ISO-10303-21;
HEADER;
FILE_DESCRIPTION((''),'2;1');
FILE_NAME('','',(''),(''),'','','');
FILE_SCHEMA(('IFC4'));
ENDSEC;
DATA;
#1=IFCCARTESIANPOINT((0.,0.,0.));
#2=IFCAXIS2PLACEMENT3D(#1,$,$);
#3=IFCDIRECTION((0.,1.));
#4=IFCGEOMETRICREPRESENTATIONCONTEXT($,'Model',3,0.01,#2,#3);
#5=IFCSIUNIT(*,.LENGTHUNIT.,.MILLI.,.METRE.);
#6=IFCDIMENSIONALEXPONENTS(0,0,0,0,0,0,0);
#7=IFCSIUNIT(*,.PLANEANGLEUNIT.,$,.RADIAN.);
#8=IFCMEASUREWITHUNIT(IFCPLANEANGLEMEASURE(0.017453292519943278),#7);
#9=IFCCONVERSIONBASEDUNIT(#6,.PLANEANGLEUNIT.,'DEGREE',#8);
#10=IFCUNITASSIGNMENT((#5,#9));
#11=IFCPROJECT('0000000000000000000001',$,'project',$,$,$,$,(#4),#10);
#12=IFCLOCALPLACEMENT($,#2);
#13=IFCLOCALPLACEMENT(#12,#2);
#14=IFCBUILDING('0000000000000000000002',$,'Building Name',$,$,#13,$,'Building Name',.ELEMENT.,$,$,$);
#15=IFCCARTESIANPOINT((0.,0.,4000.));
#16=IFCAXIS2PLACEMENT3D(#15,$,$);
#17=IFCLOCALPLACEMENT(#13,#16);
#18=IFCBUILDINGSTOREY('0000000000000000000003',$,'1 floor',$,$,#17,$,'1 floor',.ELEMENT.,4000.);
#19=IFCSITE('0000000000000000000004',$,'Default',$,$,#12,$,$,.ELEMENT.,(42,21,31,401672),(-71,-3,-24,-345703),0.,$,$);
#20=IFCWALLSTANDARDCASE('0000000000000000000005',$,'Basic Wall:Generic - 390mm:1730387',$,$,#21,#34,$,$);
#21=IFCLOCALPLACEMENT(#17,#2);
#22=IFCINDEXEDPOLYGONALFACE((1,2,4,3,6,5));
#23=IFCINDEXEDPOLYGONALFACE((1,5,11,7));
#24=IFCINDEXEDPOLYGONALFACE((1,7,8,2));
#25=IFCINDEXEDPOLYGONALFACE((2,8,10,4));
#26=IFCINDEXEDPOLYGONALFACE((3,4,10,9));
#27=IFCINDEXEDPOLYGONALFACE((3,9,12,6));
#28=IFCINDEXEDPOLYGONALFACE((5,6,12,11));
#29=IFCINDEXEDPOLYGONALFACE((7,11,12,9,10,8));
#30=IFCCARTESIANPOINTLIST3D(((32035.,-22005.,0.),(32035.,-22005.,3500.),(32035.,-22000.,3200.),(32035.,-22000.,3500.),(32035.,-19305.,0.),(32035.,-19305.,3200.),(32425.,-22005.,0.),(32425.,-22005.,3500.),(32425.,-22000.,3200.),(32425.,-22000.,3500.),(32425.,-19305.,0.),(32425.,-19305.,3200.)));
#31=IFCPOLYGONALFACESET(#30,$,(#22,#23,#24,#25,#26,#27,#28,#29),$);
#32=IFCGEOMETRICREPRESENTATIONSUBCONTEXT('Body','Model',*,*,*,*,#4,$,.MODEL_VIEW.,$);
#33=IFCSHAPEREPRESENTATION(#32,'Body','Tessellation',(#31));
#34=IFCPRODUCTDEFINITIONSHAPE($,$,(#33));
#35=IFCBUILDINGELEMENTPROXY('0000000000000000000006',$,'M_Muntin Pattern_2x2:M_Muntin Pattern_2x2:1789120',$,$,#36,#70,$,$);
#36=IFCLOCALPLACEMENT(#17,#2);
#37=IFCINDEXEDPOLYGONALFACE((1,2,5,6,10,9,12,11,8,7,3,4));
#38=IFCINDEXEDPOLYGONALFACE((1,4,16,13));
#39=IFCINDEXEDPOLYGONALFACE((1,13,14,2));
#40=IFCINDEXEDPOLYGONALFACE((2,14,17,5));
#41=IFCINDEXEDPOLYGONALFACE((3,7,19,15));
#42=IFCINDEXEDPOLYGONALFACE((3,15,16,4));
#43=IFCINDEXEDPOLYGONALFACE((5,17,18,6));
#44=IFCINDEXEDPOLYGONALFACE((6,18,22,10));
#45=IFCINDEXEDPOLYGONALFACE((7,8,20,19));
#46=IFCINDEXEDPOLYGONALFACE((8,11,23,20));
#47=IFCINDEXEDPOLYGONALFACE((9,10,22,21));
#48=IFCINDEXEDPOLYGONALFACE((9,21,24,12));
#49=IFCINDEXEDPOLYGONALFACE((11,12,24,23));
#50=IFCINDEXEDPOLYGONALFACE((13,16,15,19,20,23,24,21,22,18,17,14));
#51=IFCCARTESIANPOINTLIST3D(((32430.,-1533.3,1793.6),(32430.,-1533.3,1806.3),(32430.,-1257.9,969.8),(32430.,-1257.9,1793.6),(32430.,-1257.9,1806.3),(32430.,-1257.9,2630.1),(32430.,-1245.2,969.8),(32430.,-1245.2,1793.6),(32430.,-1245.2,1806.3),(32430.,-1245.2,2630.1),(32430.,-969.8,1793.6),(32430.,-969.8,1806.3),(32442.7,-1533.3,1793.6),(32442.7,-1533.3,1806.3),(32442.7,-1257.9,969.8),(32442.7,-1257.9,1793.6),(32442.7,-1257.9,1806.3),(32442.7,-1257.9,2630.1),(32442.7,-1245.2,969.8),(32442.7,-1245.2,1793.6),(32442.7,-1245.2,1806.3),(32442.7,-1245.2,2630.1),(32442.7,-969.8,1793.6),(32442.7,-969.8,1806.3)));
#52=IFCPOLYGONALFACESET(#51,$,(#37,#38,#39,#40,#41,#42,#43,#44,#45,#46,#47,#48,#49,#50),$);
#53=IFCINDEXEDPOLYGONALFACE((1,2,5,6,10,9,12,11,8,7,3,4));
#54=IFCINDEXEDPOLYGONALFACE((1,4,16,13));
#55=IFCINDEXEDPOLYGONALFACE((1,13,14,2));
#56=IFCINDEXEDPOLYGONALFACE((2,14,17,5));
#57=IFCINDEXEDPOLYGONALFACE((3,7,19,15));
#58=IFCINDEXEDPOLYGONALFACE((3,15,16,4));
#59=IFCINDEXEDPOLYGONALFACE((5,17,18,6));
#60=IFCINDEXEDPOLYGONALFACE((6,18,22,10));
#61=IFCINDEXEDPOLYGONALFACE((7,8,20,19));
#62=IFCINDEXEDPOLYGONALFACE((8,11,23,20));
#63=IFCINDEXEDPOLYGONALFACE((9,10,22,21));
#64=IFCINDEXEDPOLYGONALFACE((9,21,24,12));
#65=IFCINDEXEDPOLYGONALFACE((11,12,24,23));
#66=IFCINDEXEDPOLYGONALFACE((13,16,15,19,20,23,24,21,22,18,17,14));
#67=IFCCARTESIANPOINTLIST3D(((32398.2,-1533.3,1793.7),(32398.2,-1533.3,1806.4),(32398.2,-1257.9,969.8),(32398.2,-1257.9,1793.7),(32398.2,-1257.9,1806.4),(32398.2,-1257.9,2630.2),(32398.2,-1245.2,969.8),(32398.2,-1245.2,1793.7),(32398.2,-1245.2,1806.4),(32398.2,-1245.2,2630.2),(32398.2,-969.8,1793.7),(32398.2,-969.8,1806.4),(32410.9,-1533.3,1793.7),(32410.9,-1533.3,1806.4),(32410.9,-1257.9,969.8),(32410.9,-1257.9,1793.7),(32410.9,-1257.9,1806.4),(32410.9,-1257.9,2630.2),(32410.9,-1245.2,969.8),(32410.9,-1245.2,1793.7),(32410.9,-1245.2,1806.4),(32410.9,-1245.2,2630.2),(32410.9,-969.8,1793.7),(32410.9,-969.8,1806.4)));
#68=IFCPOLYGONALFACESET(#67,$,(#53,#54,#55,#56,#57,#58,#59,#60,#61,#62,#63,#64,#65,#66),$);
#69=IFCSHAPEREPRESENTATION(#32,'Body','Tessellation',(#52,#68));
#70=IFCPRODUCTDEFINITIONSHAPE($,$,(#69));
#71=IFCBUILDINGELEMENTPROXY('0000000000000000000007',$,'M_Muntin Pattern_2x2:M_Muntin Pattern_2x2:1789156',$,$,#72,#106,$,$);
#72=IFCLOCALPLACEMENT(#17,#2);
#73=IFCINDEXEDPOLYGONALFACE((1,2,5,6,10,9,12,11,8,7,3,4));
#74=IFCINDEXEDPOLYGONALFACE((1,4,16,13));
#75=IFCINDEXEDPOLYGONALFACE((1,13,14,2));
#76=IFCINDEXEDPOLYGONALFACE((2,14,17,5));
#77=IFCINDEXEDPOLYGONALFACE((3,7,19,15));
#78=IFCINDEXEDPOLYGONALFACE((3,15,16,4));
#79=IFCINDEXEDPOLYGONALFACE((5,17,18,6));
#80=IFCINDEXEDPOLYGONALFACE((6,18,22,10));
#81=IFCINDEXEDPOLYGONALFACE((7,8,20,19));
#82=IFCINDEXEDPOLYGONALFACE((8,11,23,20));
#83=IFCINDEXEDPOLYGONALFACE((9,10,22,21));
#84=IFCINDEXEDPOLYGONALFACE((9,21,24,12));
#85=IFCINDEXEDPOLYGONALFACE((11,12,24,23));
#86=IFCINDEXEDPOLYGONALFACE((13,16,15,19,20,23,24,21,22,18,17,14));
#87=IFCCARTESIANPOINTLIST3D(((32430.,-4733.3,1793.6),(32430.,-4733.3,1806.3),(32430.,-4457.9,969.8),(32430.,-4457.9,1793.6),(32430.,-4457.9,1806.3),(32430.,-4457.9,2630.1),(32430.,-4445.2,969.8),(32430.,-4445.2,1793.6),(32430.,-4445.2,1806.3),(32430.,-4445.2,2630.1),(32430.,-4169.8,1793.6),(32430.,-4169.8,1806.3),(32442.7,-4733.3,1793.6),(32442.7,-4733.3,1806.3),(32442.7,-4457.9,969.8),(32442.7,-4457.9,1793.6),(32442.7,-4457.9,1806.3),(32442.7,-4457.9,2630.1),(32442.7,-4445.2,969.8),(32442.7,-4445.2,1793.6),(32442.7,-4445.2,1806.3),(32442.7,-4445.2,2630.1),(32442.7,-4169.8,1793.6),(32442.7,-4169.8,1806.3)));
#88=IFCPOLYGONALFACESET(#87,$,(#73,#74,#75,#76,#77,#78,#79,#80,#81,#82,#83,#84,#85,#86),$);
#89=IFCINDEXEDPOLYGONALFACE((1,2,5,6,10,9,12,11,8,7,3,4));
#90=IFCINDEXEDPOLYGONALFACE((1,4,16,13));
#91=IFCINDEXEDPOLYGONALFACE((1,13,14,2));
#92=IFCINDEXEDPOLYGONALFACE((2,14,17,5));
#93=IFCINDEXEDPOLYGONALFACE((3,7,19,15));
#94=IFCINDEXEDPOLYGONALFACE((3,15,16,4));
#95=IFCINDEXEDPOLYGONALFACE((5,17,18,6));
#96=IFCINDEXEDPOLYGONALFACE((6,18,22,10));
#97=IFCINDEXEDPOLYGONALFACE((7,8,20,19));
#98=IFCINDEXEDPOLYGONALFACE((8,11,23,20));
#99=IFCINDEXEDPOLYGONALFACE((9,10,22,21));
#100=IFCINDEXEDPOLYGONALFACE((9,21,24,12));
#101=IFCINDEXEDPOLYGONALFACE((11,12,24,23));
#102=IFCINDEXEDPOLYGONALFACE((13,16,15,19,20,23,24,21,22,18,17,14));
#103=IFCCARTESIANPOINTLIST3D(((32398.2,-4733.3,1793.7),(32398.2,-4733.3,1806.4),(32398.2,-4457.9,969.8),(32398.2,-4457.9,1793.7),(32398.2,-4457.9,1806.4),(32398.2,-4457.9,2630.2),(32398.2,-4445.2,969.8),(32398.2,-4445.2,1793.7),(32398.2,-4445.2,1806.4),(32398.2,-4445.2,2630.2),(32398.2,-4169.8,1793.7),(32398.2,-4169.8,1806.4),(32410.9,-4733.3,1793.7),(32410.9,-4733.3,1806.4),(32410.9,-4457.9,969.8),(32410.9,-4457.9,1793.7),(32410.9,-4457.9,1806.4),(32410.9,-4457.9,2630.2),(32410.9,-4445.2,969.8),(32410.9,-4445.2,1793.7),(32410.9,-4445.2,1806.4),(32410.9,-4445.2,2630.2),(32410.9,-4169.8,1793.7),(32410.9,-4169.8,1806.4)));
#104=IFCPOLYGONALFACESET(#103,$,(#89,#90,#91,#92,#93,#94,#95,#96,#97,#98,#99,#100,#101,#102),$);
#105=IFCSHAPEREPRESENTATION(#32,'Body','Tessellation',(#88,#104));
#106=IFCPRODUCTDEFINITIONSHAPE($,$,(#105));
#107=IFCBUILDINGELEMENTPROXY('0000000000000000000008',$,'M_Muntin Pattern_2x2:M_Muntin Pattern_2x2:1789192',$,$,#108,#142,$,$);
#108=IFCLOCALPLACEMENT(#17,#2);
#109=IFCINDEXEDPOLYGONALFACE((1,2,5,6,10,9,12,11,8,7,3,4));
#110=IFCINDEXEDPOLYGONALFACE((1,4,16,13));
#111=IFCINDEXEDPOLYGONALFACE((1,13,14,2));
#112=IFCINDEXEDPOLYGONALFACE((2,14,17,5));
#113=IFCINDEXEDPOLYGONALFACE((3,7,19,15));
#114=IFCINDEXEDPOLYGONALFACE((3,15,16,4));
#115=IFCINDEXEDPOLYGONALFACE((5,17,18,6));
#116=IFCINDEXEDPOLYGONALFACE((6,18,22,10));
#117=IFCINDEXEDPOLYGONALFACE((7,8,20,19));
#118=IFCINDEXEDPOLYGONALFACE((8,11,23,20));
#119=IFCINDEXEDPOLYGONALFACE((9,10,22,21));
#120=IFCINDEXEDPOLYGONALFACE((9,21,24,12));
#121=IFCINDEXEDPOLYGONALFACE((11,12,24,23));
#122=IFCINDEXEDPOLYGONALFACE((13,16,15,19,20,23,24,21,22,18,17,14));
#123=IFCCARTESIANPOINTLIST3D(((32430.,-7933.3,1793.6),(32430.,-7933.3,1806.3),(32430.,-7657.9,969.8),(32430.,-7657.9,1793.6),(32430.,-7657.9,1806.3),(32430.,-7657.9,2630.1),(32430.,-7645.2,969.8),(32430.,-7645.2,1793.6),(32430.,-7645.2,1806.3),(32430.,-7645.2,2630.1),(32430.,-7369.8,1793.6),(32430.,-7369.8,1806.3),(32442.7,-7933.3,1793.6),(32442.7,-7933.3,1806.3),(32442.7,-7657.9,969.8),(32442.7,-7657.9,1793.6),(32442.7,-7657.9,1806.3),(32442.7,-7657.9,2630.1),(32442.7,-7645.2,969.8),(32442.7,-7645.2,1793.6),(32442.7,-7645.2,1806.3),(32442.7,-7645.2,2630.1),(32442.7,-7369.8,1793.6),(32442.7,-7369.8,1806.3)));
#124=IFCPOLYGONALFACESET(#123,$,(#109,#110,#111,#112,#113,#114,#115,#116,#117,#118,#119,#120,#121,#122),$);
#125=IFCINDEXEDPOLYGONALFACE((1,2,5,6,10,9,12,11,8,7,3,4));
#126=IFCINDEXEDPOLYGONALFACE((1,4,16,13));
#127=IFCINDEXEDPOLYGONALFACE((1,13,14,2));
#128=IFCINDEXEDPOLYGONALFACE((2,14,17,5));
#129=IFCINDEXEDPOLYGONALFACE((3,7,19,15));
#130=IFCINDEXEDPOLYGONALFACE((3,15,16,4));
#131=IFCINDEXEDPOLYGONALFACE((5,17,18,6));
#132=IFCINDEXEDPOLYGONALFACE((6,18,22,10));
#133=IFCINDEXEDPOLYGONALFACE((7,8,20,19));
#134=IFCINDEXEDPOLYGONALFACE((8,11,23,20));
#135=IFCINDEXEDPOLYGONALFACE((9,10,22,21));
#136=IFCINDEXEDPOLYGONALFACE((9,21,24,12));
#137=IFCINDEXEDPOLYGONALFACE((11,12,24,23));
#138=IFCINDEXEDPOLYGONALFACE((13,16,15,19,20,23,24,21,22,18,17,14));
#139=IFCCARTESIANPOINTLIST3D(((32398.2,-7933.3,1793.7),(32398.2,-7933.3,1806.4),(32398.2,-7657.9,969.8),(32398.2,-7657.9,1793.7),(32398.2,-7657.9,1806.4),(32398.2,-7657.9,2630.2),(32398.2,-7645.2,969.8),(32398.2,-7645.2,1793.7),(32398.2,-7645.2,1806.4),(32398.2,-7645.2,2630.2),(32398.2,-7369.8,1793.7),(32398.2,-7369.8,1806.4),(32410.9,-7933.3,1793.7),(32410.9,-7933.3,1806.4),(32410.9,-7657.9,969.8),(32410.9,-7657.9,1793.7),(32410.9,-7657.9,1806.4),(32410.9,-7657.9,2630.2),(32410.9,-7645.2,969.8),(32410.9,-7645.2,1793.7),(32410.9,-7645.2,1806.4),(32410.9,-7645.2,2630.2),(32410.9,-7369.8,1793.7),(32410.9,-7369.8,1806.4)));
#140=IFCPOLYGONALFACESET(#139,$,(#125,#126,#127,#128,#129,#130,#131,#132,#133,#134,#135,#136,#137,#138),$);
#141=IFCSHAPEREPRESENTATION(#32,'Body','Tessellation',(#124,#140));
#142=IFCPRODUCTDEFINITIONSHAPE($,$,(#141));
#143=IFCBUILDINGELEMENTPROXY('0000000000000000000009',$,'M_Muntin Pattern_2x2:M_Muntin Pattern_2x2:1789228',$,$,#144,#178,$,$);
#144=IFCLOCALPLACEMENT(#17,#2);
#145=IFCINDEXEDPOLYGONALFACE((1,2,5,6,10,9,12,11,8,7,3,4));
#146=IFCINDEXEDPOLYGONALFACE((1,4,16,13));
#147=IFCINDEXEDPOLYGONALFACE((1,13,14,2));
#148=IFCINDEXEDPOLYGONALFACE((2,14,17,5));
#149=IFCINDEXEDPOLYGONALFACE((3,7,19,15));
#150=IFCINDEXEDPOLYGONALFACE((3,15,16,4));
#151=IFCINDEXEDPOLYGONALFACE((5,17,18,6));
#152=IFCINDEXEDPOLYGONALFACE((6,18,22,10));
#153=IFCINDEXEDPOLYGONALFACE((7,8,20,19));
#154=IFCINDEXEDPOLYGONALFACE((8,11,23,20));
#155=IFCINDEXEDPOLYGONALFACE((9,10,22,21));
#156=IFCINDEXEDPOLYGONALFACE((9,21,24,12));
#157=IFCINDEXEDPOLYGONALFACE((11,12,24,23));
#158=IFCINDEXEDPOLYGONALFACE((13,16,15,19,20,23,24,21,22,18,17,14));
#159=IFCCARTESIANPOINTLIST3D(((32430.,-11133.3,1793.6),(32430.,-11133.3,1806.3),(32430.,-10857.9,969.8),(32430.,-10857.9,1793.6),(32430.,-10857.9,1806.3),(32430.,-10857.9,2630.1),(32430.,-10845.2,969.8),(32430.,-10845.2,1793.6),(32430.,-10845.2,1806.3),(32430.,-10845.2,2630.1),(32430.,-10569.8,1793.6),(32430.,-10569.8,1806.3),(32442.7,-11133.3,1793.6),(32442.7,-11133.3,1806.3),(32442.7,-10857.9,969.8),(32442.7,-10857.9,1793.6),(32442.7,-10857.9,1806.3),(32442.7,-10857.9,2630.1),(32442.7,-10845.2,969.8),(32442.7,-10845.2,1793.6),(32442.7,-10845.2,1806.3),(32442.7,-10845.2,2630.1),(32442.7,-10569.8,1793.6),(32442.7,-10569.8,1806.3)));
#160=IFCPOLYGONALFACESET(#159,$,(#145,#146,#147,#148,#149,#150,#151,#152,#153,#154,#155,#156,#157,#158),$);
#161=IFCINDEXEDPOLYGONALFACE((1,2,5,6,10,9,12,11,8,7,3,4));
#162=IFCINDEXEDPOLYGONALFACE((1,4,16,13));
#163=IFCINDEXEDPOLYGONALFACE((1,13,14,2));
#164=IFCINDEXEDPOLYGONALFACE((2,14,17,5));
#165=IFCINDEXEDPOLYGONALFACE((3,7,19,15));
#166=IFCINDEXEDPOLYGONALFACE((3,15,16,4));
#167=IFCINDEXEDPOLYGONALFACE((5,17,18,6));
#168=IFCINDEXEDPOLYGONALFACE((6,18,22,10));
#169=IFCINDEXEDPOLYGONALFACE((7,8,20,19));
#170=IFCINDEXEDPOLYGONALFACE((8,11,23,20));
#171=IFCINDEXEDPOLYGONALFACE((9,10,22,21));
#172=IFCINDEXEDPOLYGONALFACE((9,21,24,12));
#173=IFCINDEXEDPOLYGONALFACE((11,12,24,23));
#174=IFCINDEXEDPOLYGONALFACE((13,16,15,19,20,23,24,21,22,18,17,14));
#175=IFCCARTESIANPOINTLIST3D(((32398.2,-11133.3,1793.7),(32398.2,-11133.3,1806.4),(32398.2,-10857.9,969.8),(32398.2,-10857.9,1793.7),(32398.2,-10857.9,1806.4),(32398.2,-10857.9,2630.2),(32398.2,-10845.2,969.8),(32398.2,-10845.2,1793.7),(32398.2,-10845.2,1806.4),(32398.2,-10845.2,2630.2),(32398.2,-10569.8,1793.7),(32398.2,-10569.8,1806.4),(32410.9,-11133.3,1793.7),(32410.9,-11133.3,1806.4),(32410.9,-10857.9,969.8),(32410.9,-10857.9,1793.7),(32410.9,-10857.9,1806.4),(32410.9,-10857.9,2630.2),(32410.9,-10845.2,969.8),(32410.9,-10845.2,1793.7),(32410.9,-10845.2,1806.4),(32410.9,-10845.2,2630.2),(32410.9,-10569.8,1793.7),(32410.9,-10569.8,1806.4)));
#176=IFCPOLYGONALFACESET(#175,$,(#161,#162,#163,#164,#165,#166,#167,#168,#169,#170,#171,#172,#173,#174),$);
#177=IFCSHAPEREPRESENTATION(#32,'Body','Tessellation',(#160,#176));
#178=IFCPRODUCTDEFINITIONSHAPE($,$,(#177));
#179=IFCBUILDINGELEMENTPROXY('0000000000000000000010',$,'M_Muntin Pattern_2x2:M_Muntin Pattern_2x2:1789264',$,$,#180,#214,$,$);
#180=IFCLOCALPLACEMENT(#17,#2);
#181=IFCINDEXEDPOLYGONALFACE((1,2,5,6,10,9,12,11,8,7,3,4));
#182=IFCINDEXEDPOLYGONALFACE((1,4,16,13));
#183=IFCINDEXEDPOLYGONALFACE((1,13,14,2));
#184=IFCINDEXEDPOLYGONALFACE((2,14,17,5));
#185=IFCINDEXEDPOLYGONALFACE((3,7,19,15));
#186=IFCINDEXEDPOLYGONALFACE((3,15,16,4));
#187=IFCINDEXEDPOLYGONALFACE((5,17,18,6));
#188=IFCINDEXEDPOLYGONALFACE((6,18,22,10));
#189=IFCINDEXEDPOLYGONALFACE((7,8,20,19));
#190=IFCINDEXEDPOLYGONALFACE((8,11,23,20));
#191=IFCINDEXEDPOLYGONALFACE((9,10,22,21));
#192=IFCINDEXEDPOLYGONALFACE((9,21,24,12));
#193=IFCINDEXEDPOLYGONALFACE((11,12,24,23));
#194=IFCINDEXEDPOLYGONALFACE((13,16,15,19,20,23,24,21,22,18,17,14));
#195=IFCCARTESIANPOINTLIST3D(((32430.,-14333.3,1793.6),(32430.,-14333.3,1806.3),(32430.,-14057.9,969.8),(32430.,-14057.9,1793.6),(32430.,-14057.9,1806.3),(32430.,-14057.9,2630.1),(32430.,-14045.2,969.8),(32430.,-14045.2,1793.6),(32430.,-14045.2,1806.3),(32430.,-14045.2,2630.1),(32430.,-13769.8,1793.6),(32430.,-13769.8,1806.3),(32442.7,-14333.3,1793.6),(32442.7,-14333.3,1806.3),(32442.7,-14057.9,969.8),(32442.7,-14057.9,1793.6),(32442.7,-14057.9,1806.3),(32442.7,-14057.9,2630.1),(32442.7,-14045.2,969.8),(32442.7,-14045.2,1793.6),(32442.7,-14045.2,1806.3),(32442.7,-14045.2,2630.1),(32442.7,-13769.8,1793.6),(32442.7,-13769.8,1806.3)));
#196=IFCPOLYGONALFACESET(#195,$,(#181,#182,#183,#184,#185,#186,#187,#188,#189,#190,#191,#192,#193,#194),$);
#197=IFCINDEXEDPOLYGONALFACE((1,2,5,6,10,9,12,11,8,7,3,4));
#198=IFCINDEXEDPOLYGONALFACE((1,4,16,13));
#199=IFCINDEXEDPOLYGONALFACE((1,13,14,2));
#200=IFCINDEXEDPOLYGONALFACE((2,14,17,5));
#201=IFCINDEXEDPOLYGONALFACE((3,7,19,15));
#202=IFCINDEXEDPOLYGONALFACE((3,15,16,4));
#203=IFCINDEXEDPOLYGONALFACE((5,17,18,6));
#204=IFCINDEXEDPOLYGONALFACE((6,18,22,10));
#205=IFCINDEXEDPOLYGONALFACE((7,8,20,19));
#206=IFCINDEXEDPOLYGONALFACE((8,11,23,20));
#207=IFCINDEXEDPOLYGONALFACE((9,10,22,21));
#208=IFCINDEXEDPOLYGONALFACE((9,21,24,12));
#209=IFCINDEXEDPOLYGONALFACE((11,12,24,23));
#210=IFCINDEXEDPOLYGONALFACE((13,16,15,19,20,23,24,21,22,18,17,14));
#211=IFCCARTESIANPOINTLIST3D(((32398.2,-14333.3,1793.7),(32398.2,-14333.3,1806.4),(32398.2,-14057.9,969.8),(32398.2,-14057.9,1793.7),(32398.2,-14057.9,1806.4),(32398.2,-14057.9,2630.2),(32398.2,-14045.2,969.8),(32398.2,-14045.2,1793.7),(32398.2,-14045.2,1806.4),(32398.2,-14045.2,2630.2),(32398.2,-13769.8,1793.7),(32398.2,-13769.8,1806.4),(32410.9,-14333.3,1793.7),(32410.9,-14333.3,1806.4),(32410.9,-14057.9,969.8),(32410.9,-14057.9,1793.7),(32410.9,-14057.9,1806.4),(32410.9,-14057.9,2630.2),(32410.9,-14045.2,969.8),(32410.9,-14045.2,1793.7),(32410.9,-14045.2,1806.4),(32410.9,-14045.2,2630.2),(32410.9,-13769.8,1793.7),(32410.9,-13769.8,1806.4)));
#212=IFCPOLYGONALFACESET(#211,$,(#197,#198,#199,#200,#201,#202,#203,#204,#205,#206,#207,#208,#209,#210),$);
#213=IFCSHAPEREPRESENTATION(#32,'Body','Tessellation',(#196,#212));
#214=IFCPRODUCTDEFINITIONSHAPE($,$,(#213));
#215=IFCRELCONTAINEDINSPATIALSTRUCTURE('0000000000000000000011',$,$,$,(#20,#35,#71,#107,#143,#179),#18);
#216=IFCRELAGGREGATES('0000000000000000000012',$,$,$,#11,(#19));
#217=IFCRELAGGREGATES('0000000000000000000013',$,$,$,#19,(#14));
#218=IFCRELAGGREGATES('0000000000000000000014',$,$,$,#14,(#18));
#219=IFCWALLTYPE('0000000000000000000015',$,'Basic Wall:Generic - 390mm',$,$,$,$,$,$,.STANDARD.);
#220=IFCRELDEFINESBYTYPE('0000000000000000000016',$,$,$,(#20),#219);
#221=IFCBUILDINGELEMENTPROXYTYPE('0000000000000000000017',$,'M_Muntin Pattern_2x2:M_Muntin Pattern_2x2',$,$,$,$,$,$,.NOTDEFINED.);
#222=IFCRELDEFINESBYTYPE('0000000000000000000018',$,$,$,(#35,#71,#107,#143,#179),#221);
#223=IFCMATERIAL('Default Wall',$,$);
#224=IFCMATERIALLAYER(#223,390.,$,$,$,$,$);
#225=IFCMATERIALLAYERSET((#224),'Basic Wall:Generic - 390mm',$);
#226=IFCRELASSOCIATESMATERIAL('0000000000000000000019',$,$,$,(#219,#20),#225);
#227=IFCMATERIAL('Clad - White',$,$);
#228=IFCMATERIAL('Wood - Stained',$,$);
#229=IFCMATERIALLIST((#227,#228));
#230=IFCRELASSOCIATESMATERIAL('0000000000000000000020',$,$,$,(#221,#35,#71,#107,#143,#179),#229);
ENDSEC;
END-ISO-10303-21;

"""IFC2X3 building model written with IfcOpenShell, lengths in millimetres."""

from ifc_helpers import new_model, entity, si_unit, converted_unit, direction, frame, frame_2d, origin, place, context, subcontext, project, spatial, polyline, rectangle, outline, extrude, clip, bounded_halfspace, source, transform, mapped, material, material_list, layer, layer_set, layer_usage, type_object, type_shapes, element, save


model = new_model("IFC2X3")

# Units and contexts
model_context = context("Model", 3, precision=0.01, world=origin(), true_north=direction((0.0, 1.0)))
body_context = subcontext(model_context, "Body", "Model", "MODEL_VIEW")
ifc_project = project(units=[si_unit("LENGTHUNIT", "METRE", prefix="MILLI"), converted_unit("PLANEANGLEUNIT", "DEGREE", entity("IfcPlaneAngleMeasure", 0.017453292519943278), si_unit("PLANEANGLEUNIT", "RADIAN"), dimensions=[0, 0, 0, 0, 0, 0, 0])], contexts=[model_context])

# Site, building, storey
site_placement = place(None, origin())
site = spatial("IfcSite", under=ifc_project, at=site_placement, Name="Default", CompositionType="ELEMENT", RefLatitude=(42, 21, 31, 401672), RefLongitude=(-71, -3, -24, -345703), RefElevation=0.0)
building_placement = place(site_placement, origin())
building = spatial("IfcBuilding", under=site, at=building_placement, Name="Building Name", LongName="Building Name", CompositionType="ELEMENT")
storey_placement = place(building_placement, frame((0.0, 0.0, 4000.0)))
storey = spatial("IfcBuildingStorey", under=building, at=storey_placement, Name="1 floor", LongName="1 floor", CompositionType="ELEMENT", Elevation=4000.0)

# Wall
ifc_material_1 = material(Name="Default Wall")
ifc_layer = layer(ifc_material_1, 390.0)
ifc_layer_set = layer_set([ifc_layer], Name="Basic Wall:Generic - 390mm")
ifc_layer_usage = layer_usage(ifc_layer_set, "AXIS2", "NEGATIVE", 195.0)
wall_type = type_object("IfcWallType", Name="Basic Wall:Generic - 390mm", PredefinedType="STANDARD", material=ifc_layer_set)
wall_placement = place(storey_placement, frame((32230.0, -19305.0, 0.0), z_axis=(0.0, 0.0, 1.0), x_axis=(0.0, -1.0, 0.0)))
element("IfcWallStandardCase", 1, at=wall_placement, inside=storey, type_object=wall_type, material=ifc_layer_usage, Name="Basic Wall:Generic - 390mm:1730387", context=body_context, shape_type="Clipping", body=[
    clip(extrude(rectangle(XDim=2700.0, YDim=390.0, at=frame_2d((1350.0, 0.0), x_axis=(-1.0, 0.0))), origin(), (0.0, 0.0, 1.0), 3500.0), bounded_halfspace(frame((0.0, -195.0, 3200.0), z_axis=(0.0, 0.0, -1.0), x_axis=(-1.0, 0.0, 0.0)), True, frame((0.0, -195.0, 3200.0)), polyline([(0.0, 0.0), (2695.0, 0.0), (2695.0, 390.0), (0.0, 390.0), (0.0, 5.0), (0.0, 0.0)]))),
])

# Building element proxies
ifc_material_2 = material(Name="Clad - White")
ifc_material_3 = material(Name="Wood - Stained")
ifc_material_list = material_list([ifc_material_2, ifc_material_3])
building_element_proxy_type_1 = type_object("IfcBuildingElementProxyType", Name="M_Muntin Pattern_2x2:M_Muntin Pattern_2x2", PredefinedType="NOTDEFINED", material=ifc_material_list)
shared_shape_1 = source(origin(), body_context, "Body", "SweptSolid", [
    extrude(outline(polyline([(6.4, -6.4), (830.1, -6.4), (830.1, 6.3), (6.4, 6.3), (6.4, 281.7), (-6.3, 281.7), (-6.3, 6.3), (-830.2, 6.3), (-830.2, -6.4), (-6.3, -6.4), (-6.3, -281.7), (6.4, -281.7), (6.4, -6.4)])), frame((0.0, 9.5, 830.1), z_axis=(0.0, 1.0, 0.0), x_axis=(0.0, 0.0, 1.0)), (0.0, 0.0, 1.0), 12.7),
    extrude(outline(polyline([(6.4, -6.4), (830.2, -6.4), (830.2, 6.3), (6.4, 6.3), (6.4, 281.7), (-6.3, 281.7), (-6.3, 6.3), (-830.2, 6.3), (-830.2, -6.4), (-6.3, -6.4), (-6.3, -281.7), (6.4, -281.7), (6.4, -6.4)])), frame((0.0, -22.2, 830.2), z_axis=(0.0, 1.0, 0.0), x_axis=(0.0, 0.0, 1.0)), (0.0, 0.0, 1.0), 12.7),
])
type_shapes(building_element_proxy_type_1, [shared_shape_1])
for number, where, z_axis, x_axis, name in (
    (2, (32420.5, -1251.6, 969.8), (0.0, 0.0, 1.0), (0.0, -1.0, 0.0), "M_Muntin Pattern_2x2:M_Muntin Pattern_2x2:1789120"),
    (3, (32420.5, -4451.6, 969.8), (0.0, 0.0, 1.0), (0.0, -1.0, 0.0), "M_Muntin Pattern_2x2:M_Muntin Pattern_2x2:1789156"),
    (4, (32420.5, -7651.6, 969.8), (0.0, 0.0, 1.0), (0.0, -1.0, 0.0), "M_Muntin Pattern_2x2:M_Muntin Pattern_2x2:1789192"),
    (5, (32420.5, -10851.6, 969.8), (0.0, 0.0, 1.0), (0.0, -1.0, 0.0), "M_Muntin Pattern_2x2:M_Muntin Pattern_2x2:1789228"),
    (6, (32420.5, -14051.6, 969.8), (0.0, 0.0, 1.0), (0.0, -1.0, 0.0), "M_Muntin Pattern_2x2:M_Muntin Pattern_2x2:1789264"),
):
    element("IfcBuildingElementProxy", number, at=place(storey_placement, frame(where, z_axis=z_axis, x_axis=x_axis)), inside=storey, type_object=building_element_proxy_type_1, material=ifc_material_list, Name=name, context=body_context, shape_type="MappedRepresentation", body=[
        mapped(shared_shape_1, transform((0.0, 0.0, 0.0), scale=1.0)),
    ])

save(model, "model.ifc")
